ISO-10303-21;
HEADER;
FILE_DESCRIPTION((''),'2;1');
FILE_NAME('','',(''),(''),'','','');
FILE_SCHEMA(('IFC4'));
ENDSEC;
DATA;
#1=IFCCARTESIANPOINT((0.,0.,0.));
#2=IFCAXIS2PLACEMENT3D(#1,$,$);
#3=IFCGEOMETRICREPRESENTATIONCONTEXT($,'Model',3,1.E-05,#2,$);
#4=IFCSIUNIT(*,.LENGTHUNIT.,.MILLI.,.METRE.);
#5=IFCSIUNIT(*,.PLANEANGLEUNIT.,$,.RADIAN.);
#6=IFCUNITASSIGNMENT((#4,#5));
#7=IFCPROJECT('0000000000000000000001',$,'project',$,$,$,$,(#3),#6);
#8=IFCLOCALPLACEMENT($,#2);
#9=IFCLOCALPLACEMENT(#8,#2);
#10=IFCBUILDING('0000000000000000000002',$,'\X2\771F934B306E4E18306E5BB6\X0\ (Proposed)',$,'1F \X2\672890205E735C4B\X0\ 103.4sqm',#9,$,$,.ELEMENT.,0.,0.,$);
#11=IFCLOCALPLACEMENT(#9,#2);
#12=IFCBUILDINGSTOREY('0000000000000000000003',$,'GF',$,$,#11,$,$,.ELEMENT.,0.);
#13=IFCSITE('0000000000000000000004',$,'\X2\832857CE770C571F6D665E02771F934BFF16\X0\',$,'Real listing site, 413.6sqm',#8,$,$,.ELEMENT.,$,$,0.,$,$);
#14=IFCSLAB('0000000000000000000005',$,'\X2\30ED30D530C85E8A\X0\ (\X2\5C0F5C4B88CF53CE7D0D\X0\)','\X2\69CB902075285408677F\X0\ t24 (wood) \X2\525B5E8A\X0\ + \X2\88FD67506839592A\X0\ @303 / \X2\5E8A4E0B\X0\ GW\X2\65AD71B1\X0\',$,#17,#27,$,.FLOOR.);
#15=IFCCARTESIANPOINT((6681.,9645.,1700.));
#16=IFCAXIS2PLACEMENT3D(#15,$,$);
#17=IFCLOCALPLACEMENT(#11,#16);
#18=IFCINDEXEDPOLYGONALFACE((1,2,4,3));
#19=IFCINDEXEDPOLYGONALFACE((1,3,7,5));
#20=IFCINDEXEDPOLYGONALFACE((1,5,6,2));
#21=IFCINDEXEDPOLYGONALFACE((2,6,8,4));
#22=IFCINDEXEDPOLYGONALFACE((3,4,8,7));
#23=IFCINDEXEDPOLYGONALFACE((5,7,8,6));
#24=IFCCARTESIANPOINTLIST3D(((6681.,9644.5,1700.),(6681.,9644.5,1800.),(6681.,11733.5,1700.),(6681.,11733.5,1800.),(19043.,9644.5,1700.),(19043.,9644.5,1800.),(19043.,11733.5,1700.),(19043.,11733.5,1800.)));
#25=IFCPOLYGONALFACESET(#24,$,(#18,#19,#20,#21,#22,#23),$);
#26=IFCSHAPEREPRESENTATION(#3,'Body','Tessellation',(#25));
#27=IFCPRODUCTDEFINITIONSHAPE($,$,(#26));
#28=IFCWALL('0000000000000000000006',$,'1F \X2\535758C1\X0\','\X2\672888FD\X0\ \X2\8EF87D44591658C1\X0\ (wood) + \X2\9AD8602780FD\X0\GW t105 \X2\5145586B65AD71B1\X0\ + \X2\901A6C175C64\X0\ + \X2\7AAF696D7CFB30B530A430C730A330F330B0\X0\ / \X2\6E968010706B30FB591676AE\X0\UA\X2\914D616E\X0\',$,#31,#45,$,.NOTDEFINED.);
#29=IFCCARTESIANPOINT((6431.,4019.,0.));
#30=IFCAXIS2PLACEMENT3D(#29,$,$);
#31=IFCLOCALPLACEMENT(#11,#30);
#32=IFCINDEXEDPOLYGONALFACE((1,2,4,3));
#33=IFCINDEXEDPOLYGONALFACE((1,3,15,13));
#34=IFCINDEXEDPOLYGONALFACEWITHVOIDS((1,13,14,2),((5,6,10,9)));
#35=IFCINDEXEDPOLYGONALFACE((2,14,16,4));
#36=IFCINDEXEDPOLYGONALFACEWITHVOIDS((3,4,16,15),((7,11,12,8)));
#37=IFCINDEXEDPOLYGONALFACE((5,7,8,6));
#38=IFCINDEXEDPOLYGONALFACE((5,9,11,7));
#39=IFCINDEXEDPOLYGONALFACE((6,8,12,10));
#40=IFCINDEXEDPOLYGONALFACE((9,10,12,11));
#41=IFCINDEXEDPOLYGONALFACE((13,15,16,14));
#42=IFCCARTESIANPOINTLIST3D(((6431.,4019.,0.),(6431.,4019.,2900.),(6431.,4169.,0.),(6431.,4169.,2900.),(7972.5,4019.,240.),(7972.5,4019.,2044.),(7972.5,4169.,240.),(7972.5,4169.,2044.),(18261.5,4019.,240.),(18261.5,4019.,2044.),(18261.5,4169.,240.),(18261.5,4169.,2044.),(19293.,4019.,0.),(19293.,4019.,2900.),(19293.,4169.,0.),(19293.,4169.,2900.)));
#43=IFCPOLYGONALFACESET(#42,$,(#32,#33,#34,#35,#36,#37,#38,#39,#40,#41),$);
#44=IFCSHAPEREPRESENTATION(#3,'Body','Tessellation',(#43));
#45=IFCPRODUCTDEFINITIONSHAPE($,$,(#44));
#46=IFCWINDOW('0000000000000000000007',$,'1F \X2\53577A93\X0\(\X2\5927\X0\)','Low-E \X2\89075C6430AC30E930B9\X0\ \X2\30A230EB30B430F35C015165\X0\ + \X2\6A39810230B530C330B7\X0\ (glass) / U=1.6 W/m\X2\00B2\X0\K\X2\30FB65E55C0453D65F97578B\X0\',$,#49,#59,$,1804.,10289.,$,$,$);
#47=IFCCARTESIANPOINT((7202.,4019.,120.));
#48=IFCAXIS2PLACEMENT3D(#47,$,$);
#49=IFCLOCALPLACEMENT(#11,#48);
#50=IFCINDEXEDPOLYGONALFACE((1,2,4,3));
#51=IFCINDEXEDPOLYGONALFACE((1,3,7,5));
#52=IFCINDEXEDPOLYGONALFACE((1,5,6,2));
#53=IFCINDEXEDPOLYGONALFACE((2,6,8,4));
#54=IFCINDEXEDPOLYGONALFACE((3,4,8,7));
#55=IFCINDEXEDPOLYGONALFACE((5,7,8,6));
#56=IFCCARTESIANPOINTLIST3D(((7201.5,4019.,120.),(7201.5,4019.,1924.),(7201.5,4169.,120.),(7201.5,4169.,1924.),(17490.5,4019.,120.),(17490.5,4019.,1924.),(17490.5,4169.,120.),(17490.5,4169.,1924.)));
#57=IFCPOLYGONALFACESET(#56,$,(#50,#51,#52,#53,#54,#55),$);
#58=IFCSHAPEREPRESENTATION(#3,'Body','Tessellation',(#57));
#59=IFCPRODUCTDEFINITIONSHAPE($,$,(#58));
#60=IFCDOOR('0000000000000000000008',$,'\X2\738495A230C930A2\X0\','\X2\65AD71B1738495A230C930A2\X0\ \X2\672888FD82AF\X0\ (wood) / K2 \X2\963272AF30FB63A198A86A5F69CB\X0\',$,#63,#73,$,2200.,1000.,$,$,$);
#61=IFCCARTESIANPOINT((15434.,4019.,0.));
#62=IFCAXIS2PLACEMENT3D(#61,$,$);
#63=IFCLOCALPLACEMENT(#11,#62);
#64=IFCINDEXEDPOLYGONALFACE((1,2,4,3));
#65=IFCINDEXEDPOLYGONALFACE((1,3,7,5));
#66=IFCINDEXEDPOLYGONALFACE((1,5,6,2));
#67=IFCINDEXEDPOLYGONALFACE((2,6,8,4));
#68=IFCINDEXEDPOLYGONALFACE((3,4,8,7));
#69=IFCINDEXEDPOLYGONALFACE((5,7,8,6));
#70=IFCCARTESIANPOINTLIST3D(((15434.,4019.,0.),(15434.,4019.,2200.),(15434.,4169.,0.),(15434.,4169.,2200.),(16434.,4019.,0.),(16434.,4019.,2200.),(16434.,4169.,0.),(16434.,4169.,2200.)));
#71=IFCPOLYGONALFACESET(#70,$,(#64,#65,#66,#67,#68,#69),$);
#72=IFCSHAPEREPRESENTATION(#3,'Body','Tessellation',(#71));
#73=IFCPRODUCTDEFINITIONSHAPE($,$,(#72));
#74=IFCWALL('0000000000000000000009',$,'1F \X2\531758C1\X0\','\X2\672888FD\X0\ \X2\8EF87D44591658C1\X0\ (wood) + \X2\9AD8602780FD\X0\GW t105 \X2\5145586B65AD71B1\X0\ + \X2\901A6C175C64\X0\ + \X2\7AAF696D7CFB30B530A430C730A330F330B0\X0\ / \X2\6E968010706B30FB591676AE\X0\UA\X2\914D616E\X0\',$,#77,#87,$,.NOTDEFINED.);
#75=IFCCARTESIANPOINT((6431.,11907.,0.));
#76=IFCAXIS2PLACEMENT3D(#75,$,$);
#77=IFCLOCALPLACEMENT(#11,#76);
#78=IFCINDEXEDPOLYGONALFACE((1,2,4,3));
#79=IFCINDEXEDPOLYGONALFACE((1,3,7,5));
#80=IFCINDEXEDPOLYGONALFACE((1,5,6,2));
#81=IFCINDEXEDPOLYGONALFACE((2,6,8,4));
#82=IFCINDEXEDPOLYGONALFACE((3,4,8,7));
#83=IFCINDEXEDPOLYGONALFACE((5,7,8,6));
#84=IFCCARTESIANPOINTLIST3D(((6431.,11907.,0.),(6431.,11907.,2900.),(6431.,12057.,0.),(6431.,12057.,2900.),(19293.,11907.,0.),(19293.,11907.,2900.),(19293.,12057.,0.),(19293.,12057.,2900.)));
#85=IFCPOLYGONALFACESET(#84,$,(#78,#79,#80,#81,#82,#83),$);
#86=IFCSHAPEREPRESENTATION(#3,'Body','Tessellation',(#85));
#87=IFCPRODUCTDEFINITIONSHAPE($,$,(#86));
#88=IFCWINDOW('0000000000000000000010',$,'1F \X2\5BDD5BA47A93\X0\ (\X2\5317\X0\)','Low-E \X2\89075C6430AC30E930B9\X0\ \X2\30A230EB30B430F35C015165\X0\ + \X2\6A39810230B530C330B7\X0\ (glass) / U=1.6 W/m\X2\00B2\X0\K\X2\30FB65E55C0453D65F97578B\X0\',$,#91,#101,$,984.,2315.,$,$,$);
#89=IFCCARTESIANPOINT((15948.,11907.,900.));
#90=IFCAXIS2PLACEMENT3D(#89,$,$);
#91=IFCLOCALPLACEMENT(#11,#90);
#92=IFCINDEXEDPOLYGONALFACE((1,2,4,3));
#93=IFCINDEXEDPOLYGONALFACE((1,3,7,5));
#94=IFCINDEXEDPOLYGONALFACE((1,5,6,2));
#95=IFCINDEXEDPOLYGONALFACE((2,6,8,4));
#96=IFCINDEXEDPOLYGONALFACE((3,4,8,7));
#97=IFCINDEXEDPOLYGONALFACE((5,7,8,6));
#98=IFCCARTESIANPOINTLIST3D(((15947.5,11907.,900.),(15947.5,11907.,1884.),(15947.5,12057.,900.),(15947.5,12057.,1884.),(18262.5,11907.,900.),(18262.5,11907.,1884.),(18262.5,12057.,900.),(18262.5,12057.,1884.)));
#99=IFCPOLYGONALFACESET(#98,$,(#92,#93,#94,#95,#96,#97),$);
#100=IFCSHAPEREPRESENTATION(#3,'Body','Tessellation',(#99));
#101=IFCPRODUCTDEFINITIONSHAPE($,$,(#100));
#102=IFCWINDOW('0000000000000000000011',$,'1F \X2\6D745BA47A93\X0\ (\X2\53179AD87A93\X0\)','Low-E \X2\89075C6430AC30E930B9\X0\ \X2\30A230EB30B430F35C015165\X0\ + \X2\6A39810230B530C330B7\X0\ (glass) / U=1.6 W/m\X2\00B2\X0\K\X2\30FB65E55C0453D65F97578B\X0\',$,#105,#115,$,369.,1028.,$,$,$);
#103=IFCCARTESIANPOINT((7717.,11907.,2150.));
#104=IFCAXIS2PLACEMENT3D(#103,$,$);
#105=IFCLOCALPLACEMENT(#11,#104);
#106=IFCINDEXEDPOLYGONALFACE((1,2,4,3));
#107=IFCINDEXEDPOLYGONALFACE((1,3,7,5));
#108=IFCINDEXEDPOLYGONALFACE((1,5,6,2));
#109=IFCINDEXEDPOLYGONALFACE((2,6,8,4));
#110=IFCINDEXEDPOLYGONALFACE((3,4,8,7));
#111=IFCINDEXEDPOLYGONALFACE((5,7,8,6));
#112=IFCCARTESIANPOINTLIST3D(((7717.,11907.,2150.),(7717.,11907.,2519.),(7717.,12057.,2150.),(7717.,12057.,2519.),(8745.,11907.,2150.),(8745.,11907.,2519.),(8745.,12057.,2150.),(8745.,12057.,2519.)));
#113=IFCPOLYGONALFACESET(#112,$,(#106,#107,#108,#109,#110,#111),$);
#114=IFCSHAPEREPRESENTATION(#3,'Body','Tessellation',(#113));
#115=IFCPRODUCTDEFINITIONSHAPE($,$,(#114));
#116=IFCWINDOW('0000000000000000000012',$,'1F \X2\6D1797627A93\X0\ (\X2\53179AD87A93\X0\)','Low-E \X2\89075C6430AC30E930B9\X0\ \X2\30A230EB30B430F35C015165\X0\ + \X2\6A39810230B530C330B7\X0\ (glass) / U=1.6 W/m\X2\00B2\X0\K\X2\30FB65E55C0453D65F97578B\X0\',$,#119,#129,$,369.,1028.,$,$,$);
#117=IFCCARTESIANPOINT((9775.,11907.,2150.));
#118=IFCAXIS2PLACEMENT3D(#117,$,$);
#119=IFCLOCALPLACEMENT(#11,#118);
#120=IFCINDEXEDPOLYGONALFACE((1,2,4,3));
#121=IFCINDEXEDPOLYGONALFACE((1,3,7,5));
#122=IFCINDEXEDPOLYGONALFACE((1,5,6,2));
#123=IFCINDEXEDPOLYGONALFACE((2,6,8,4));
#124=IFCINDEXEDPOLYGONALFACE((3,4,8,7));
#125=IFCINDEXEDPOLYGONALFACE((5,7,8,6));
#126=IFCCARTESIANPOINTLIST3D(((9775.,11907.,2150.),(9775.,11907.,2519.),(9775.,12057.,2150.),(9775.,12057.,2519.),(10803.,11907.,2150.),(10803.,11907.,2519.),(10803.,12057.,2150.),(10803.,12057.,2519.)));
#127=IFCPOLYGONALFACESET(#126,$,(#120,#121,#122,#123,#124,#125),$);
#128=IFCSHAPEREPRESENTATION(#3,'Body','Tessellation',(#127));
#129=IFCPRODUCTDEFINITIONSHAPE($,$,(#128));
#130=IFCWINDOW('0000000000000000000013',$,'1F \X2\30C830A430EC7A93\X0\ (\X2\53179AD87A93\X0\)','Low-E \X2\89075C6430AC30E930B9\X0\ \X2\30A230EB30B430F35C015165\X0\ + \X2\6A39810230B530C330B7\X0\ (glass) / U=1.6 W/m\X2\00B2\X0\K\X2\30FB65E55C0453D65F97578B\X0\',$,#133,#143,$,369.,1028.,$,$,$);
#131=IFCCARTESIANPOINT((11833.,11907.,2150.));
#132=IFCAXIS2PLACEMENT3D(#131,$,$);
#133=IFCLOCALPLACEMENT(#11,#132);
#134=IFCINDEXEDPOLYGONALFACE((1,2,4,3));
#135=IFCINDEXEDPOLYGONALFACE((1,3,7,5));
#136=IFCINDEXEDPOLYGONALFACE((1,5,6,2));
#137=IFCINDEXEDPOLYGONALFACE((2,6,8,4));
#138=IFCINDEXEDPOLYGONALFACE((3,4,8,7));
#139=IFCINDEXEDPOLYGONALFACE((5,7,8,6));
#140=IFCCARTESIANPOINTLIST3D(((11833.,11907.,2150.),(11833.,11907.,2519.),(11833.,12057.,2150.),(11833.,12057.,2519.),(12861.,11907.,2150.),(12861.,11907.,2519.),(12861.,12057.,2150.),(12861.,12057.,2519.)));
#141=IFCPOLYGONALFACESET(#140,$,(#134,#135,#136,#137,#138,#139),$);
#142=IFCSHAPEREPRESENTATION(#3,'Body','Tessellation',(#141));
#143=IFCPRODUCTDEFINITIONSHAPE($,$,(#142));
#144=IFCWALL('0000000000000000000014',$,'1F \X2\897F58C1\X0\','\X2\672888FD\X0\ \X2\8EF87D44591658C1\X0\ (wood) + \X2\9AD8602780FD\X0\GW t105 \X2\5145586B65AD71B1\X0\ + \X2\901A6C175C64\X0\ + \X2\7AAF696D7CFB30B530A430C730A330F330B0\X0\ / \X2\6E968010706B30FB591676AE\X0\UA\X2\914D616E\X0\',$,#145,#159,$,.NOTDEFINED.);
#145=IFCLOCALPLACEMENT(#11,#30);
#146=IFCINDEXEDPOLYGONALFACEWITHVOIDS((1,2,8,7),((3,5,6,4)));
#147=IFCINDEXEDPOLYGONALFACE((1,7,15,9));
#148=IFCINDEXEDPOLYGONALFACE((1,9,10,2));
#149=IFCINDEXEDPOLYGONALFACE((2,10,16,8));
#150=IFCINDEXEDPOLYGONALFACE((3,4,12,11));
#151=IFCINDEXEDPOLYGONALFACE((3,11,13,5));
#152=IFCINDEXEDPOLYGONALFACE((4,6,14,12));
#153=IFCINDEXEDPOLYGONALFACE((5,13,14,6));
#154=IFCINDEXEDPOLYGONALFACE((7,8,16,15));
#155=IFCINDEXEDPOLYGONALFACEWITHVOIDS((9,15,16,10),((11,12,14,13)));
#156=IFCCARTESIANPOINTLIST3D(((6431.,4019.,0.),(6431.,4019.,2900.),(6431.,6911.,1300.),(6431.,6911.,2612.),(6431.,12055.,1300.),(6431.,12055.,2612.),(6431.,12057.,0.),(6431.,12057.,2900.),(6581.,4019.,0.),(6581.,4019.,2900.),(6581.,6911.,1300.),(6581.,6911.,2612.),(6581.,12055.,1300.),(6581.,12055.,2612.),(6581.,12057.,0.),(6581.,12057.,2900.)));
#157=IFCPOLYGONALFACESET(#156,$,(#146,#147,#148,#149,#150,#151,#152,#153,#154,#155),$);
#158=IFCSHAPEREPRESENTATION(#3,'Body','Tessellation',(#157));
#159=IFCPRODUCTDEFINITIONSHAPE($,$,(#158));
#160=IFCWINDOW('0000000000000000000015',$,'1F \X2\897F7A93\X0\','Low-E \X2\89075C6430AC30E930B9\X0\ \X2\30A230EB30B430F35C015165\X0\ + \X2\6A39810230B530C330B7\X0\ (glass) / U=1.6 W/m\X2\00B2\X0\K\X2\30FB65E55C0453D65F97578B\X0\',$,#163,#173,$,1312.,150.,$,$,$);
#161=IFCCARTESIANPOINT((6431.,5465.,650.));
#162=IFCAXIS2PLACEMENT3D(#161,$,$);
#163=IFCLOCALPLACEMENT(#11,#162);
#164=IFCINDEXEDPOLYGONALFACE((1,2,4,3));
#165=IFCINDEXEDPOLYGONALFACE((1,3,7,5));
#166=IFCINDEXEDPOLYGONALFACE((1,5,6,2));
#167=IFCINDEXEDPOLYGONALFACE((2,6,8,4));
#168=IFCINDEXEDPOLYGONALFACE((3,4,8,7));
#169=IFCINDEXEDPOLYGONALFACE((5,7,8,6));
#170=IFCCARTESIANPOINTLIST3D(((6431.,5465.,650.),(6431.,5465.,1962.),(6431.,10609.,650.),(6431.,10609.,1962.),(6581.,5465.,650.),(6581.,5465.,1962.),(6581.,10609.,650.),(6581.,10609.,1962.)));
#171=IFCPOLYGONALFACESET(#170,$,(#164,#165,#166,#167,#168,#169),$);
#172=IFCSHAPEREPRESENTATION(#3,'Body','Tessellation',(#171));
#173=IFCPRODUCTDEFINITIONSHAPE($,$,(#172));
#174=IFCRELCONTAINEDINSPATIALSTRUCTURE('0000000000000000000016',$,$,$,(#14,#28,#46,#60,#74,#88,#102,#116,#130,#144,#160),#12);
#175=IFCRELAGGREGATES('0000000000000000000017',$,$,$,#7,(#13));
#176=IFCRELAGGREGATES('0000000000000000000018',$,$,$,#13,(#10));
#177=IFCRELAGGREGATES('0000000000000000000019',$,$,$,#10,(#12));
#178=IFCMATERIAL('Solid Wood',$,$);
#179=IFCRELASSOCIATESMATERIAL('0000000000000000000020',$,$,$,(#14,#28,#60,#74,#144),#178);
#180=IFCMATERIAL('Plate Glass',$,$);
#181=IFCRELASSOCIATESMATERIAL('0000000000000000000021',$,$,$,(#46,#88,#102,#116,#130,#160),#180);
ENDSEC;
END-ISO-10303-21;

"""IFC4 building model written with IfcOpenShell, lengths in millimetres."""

from ifc_helpers import new_model, si_unit, frame, frame_2d, origin, place, context, project, spatial, rectangle, extrude, material, element, fill, save


model = new_model("IFC4")

# Units and contexts
model_context = context("Model", 3, precision=1e-05, world=origin())
ifc_project = project(units=[si_unit("LENGTHUNIT", "METRE", prefix="MILLI"), si_unit("PLANEANGLEUNIT", "RADIAN")], contexts=[model_context])

# Site, building, storey
site_placement = place(None, origin())
site = spatial("IfcSite", under=ifc_project, at=site_placement, Name="茨城県土浦市真鍋６", ObjectType="Real listing site, 413.6sqm", CompositionType="ELEMENT", RefElevation=0.0)
building_placement = place(site_placement, origin())
building = spatial("IfcBuilding", under=site, at=building_placement, Name="真鍋の丘の家 (Proposed)", ObjectType="1F 木造平屋 103.4sqm", CompositionType="ELEMENT", ElevationOfRefHeight=0.0, ElevationOfTerrain=0.0)
storey_placement = place(building_placement, origin())
storey = spatial("IfcBuildingStorey", under=building, at=storey_placement, Name="GF", CompositionType="ELEMENT", Elevation=0.0)

# Slab
ifc_material_1 = material(Name="Solid Wood")
slab_1_placement = place(storey_placement, frame((6681.0, 9645.0, 1700.0)))
element("IfcSlab", 1, at=slab_1_placement, inside=storey, material=ifc_material_1, Name="ロフト床 (小屋裏収納)", Description="構造用合板 t24 (wood) 剛床 + 製材根太 @303 / 床下 GW断熱", PredefinedType="FLOOR", context=model_context, shape_type="SweptSolid", body=[
    extrude(rectangle(XDim=12362.0, YDim=2089.0, at=frame_2d((6181.0, 1044.0))), frame((6681.0, 9645.0, 1700.0)), (0.0, 0.0, 1.0), 100.0),
])

# Wall, openings, window, door
wall_1_placement = place(storey_placement, frame((6431.0, 4019.0, 0.0)))
wall_1 = element("IfcWall", 2, at=wall_1_placement, inside=storey, material=ifc_material_1, Name="1F 南壁", Description="木製 軸組外壁 (wood) + 高性能GW t105 充填断熱 + 通気層 + 窯業系サイディング / 準耐火・外皮UA配慮", PredefinedType="NOTDEFINED", context=model_context, shape_type="SweptSolid", body=[
    extrude(rectangle(XDim=12862.0, YDim=150.0, at=frame_2d((6431.0, 75.0))), frame((6431.0, 4019.0, 0.0)), (0.0, 0.0, 1.0), 2900.0),
])
opening_1_placement = place(storey_placement, frame((7202.0, 4019.0, 120.0)))
opening_1 = element("IfcOpeningElement", 3, at=opening_1_placement, cuts=wall_1, PredefinedType="NOTDEFINED", context=model_context, shape_type="SweptSolid", body=[
    extrude(rectangle(XDim=10289.0, YDim=150.0, at=frame_2d((5144.0, 75.0))), frame((7202.0, 4019.0, 120.0)), (0.0, 0.0, 1.0), 1804.0),
])
opening_2_placement = place(storey_placement, frame((15434.0, 4019.0, 0.0)))
opening_2 = element("IfcOpeningElement", 4, at=opening_2_placement, cuts=wall_1, PredefinedType="NOTDEFINED", context=model_context, shape_type="SweptSolid", body=[
    extrude(rectangle(XDim=1000.0, YDim=150.0, at=frame_2d((500.0, 75.0))), frame((15434.0, 4019.0, 0.0)), (0.0, 0.0, 1.0), 2200.0),
])
ifc_material_2 = material(Name="Plate Glass")
window_1_placement = place(storey_placement, frame((7202.0, 4019.0, 120.0)))
window_1 = element("IfcWindow", 5, at=window_1_placement, inside=storey, material=ifc_material_2, Name="1F 南窓(大)", Description="Low-E 複層ガラス アルゴン封入 + 樹脂サッシ (glass) / U=1.6 W/m²K・日射取得型", OverallHeight=1804.0, OverallWidth=10289.0, context=model_context, shape_type="SweptSolid", body=[
    extrude(rectangle(XDim=10289.0, YDim=150.0, at=frame_2d((5144.0, 75.0))), frame((7202.0, 4019.0, 120.0)), (0.0, 0.0, 1.0), 1804.0),
])
fill(opening_1, window_1)
door_1_placement = place(storey_placement, frame((15434.0, 4019.0, 0.0)))
door_1 = element("IfcDoor", 6, at=door_1_placement, inside=storey, material=ifc_material_1, Name="玄関ドア", Description="断熱玄関ドア 木製芯 (wood) / K2 防犯・採風機構", OverallHeight=2200.0, OverallWidth=1000.0, context=model_context, shape_type="SweptSolid", body=[
    extrude(rectangle(XDim=1000.0, YDim=150.0, at=frame_2d((500.0, 75.0))), frame((15434.0, 4019.0, 0.0)), (0.0, 0.0, 1.0), 2200.0),
])
fill(opening_2, door_1)

# Wall, openings, windows
wall_2_placement = place(storey_placement, frame((6431.0, 11907.0, 0.0)))
wall_2 = element("IfcWall", 7, at=wall_2_placement, inside=storey, material=ifc_material_1, Name="1F 北壁", Description="木製 軸組外壁 (wood) + 高性能GW t105 充填断熱 + 通気層 + 窯業系サイディング / 準耐火・外皮UA配慮", PredefinedType="NOTDEFINED", context=model_context, shape_type="SweptSolid", body=[
    extrude(rectangle(XDim=12862.0, YDim=150.0, at=frame_2d((6431.0, 75.0))), frame((6431.0, 11907.0, 0.0)), (0.0, 0.0, 1.0), 2900.0),
])
opening_3_placement = place(storey_placement, frame((15948.0, 11907.0, 900.0)))
opening_3 = element("IfcOpeningElement", 8, at=opening_3_placement, cuts=wall_2, PredefinedType="NOTDEFINED", context=model_context, shape_type="SweptSolid", body=[
    extrude(rectangle(XDim=2315.0, YDim=150.0, at=frame_2d((1157.0, 75.0))), frame((15948.0, 11907.0, 900.0)), (0.0, 0.0, 1.0), 984.0),
])
opening_4_placement = place(storey_placement, frame((7717.0, 11907.0, 2150.0)))
opening_4 = element("IfcOpeningElement", 9, at=opening_4_placement, cuts=wall_2, PredefinedType="NOTDEFINED", context=model_context, shape_type="SweptSolid", body=[
    extrude(rectangle(XDim=1028.0, YDim=150.0, at=frame_2d((514.0, 75.0))), frame((7717.0, 11907.0, 2150.0)), (0.0, 0.0, 1.0), 369.0),
])
opening_5_placement = place(storey_placement, frame((9775.0, 11907.0, 2150.0)))
opening_5 = element("IfcOpeningElement", 10, at=opening_5_placement, cuts=wall_2, PredefinedType="NOTDEFINED", context=model_context, shape_type="SweptSolid", body=[
    extrude(rectangle(XDim=1028.0, YDim=150.0, at=frame_2d((514.0, 75.0))), frame((9775.0, 11907.0, 2150.0)), (0.0, 0.0, 1.0), 369.0),
])
opening_6_placement = place(storey_placement, frame((11833.0, 11907.0, 2150.0)))
opening_6 = element("IfcOpeningElement", 11, at=opening_6_placement, cuts=wall_2, PredefinedType="NOTDEFINED", context=model_context, shape_type="SweptSolid", body=[
    extrude(rectangle(XDim=1028.0, YDim=150.0, at=frame_2d((514.0, 75.0))), frame((11833.0, 11907.0, 2150.0)), (0.0, 0.0, 1.0), 369.0),
])
window_2_placement = place(storey_placement, frame((15948.0, 11907.0, 900.0)))
window_2 = element("IfcWindow", 12, at=window_2_placement, inside=storey, material=ifc_material_2, Name="1F 寝室窓 (北)", Description="Low-E 複層ガラス アルゴン封入 + 樹脂サッシ (glass) / U=1.6 W/m²K・日射取得型", OverallHeight=984.0, OverallWidth=2315.0, context=model_context, shape_type="SweptSolid", body=[
    extrude(rectangle(XDim=2315.0, YDim=150.0, at=frame_2d((1157.0, 75.0))), frame((15948.0, 11907.0, 900.0)), (0.0, 0.0, 1.0), 984.0),
])
fill(opening_3, window_2)
window_3_placement = place(storey_placement, frame((7717.0, 11907.0, 2150.0)))
window_3 = element("IfcWindow", 13, at=window_3_placement, inside=storey, material=ifc_material_2, Name="1F 浴室窓 (北高窓)", Description="Low-E 複層ガラス アルゴン封入 + 樹脂サッシ (glass) / U=1.6 W/m²K・日射取得型", OverallHeight=369.0, OverallWidth=1028.0, context=model_context, shape_type="SweptSolid", body=[
    extrude(rectangle(XDim=1028.0, YDim=150.0, at=frame_2d((514.0, 75.0))), frame((7717.0, 11907.0, 2150.0)), (0.0, 0.0, 1.0), 369.0),
])
fill(opening_4, window_3)
window_4_placement = place(storey_placement, frame((9775.0, 11907.0, 2150.0)))
window_4 = element("IfcWindow", 14, at=window_4_placement, inside=storey, material=ifc_material_2, Name="1F 洗面窓 (北高窓)", Description="Low-E 複層ガラス アルゴン封入 + 樹脂サッシ (glass) / U=1.6 W/m²K・日射取得型", OverallHeight=369.0, OverallWidth=1028.0, context=model_context, shape_type="SweptSolid", body=[
    extrude(rectangle(XDim=1028.0, YDim=150.0, at=frame_2d((514.0, 75.0))), frame((9775.0, 11907.0, 2150.0)), (0.0, 0.0, 1.0), 369.0),
])
fill(opening_5, window_4)
window_5_placement = place(storey_placement, frame((11833.0, 11907.0, 2150.0)))
window_5 = element("IfcWindow", 15, at=window_5_placement, inside=storey, material=ifc_material_2, Name="1F トイレ窓 (北高窓)", Description="Low-E 複層ガラス アルゴン封入 + 樹脂サッシ (glass) / U=1.6 W/m²K・日射取得型", OverallHeight=369.0, OverallWidth=1028.0, context=model_context, shape_type="SweptSolid", body=[
    extrude(rectangle(XDim=1028.0, YDim=150.0, at=frame_2d((514.0, 75.0))), frame((11833.0, 11907.0, 2150.0)), (0.0, 0.0, 1.0), 369.0),
])
fill(opening_6, window_5)

# Wall, opening, window
wall_3_placement = place(storey_placement, frame((6431.0, 4019.0, 0.0)))
wall_3 = element("IfcWall", 16, at=wall_3_placement, inside=storey, material=ifc_material_1, Name="1F 西壁", Description="木製 軸組外壁 (wood) + 高性能GW t105 充填断熱 + 通気層 + 窯業系サイディング / 準耐火・外皮UA配慮", PredefinedType="NOTDEFINED", context=model_context, shape_type="SweptSolid", body=[
    extrude(rectangle(XDim=150.0, YDim=8038.0, at=frame_2d((75.0, 4019.0))), frame((6431.0, 4019.0, 0.0)), (0.0, 0.0, 1.0), 2900.0),
])
opening_7_placement = place(storey_placement, frame((6431.0, 5465.0, 650.0)))
opening_7 = element("IfcOpeningElement", 17, at=opening_7_placement, cuts=wall_3, PredefinedType="NOTDEFINED", context=model_context, shape_type="SweptSolid", body=[
    extrude(rectangle(XDim=150.0, YDim=5144.0, at=frame_2d((75.0, 2572.0))), frame((6431.0, 5465.0, 650.0)), (0.0, 0.0, 1.0), 1312.0),
])
window_6_placement = place(storey_placement, frame((6431.0, 5465.0, 650.0)))
window_6 = element("IfcWindow", 18, at=window_6_placement, inside=storey, material=ifc_material_2, Name="1F 西窓", Description="Low-E 複層ガラス アルゴン封入 + 樹脂サッシ (glass) / U=1.6 W/m²K・日射取得型", OverallHeight=1312.0, OverallWidth=150.0, context=model_context, shape_type="SweptSolid", body=[
    extrude(rectangle(XDim=150.0, YDim=5144.0, at=frame_2d((75.0, 2572.0))), frame((6431.0, 5465.0, 650.0)), (0.0, 0.0, 1.0), 1312.0),
])
fill(opening_7, window_6)

save(model, "model.ifc")
